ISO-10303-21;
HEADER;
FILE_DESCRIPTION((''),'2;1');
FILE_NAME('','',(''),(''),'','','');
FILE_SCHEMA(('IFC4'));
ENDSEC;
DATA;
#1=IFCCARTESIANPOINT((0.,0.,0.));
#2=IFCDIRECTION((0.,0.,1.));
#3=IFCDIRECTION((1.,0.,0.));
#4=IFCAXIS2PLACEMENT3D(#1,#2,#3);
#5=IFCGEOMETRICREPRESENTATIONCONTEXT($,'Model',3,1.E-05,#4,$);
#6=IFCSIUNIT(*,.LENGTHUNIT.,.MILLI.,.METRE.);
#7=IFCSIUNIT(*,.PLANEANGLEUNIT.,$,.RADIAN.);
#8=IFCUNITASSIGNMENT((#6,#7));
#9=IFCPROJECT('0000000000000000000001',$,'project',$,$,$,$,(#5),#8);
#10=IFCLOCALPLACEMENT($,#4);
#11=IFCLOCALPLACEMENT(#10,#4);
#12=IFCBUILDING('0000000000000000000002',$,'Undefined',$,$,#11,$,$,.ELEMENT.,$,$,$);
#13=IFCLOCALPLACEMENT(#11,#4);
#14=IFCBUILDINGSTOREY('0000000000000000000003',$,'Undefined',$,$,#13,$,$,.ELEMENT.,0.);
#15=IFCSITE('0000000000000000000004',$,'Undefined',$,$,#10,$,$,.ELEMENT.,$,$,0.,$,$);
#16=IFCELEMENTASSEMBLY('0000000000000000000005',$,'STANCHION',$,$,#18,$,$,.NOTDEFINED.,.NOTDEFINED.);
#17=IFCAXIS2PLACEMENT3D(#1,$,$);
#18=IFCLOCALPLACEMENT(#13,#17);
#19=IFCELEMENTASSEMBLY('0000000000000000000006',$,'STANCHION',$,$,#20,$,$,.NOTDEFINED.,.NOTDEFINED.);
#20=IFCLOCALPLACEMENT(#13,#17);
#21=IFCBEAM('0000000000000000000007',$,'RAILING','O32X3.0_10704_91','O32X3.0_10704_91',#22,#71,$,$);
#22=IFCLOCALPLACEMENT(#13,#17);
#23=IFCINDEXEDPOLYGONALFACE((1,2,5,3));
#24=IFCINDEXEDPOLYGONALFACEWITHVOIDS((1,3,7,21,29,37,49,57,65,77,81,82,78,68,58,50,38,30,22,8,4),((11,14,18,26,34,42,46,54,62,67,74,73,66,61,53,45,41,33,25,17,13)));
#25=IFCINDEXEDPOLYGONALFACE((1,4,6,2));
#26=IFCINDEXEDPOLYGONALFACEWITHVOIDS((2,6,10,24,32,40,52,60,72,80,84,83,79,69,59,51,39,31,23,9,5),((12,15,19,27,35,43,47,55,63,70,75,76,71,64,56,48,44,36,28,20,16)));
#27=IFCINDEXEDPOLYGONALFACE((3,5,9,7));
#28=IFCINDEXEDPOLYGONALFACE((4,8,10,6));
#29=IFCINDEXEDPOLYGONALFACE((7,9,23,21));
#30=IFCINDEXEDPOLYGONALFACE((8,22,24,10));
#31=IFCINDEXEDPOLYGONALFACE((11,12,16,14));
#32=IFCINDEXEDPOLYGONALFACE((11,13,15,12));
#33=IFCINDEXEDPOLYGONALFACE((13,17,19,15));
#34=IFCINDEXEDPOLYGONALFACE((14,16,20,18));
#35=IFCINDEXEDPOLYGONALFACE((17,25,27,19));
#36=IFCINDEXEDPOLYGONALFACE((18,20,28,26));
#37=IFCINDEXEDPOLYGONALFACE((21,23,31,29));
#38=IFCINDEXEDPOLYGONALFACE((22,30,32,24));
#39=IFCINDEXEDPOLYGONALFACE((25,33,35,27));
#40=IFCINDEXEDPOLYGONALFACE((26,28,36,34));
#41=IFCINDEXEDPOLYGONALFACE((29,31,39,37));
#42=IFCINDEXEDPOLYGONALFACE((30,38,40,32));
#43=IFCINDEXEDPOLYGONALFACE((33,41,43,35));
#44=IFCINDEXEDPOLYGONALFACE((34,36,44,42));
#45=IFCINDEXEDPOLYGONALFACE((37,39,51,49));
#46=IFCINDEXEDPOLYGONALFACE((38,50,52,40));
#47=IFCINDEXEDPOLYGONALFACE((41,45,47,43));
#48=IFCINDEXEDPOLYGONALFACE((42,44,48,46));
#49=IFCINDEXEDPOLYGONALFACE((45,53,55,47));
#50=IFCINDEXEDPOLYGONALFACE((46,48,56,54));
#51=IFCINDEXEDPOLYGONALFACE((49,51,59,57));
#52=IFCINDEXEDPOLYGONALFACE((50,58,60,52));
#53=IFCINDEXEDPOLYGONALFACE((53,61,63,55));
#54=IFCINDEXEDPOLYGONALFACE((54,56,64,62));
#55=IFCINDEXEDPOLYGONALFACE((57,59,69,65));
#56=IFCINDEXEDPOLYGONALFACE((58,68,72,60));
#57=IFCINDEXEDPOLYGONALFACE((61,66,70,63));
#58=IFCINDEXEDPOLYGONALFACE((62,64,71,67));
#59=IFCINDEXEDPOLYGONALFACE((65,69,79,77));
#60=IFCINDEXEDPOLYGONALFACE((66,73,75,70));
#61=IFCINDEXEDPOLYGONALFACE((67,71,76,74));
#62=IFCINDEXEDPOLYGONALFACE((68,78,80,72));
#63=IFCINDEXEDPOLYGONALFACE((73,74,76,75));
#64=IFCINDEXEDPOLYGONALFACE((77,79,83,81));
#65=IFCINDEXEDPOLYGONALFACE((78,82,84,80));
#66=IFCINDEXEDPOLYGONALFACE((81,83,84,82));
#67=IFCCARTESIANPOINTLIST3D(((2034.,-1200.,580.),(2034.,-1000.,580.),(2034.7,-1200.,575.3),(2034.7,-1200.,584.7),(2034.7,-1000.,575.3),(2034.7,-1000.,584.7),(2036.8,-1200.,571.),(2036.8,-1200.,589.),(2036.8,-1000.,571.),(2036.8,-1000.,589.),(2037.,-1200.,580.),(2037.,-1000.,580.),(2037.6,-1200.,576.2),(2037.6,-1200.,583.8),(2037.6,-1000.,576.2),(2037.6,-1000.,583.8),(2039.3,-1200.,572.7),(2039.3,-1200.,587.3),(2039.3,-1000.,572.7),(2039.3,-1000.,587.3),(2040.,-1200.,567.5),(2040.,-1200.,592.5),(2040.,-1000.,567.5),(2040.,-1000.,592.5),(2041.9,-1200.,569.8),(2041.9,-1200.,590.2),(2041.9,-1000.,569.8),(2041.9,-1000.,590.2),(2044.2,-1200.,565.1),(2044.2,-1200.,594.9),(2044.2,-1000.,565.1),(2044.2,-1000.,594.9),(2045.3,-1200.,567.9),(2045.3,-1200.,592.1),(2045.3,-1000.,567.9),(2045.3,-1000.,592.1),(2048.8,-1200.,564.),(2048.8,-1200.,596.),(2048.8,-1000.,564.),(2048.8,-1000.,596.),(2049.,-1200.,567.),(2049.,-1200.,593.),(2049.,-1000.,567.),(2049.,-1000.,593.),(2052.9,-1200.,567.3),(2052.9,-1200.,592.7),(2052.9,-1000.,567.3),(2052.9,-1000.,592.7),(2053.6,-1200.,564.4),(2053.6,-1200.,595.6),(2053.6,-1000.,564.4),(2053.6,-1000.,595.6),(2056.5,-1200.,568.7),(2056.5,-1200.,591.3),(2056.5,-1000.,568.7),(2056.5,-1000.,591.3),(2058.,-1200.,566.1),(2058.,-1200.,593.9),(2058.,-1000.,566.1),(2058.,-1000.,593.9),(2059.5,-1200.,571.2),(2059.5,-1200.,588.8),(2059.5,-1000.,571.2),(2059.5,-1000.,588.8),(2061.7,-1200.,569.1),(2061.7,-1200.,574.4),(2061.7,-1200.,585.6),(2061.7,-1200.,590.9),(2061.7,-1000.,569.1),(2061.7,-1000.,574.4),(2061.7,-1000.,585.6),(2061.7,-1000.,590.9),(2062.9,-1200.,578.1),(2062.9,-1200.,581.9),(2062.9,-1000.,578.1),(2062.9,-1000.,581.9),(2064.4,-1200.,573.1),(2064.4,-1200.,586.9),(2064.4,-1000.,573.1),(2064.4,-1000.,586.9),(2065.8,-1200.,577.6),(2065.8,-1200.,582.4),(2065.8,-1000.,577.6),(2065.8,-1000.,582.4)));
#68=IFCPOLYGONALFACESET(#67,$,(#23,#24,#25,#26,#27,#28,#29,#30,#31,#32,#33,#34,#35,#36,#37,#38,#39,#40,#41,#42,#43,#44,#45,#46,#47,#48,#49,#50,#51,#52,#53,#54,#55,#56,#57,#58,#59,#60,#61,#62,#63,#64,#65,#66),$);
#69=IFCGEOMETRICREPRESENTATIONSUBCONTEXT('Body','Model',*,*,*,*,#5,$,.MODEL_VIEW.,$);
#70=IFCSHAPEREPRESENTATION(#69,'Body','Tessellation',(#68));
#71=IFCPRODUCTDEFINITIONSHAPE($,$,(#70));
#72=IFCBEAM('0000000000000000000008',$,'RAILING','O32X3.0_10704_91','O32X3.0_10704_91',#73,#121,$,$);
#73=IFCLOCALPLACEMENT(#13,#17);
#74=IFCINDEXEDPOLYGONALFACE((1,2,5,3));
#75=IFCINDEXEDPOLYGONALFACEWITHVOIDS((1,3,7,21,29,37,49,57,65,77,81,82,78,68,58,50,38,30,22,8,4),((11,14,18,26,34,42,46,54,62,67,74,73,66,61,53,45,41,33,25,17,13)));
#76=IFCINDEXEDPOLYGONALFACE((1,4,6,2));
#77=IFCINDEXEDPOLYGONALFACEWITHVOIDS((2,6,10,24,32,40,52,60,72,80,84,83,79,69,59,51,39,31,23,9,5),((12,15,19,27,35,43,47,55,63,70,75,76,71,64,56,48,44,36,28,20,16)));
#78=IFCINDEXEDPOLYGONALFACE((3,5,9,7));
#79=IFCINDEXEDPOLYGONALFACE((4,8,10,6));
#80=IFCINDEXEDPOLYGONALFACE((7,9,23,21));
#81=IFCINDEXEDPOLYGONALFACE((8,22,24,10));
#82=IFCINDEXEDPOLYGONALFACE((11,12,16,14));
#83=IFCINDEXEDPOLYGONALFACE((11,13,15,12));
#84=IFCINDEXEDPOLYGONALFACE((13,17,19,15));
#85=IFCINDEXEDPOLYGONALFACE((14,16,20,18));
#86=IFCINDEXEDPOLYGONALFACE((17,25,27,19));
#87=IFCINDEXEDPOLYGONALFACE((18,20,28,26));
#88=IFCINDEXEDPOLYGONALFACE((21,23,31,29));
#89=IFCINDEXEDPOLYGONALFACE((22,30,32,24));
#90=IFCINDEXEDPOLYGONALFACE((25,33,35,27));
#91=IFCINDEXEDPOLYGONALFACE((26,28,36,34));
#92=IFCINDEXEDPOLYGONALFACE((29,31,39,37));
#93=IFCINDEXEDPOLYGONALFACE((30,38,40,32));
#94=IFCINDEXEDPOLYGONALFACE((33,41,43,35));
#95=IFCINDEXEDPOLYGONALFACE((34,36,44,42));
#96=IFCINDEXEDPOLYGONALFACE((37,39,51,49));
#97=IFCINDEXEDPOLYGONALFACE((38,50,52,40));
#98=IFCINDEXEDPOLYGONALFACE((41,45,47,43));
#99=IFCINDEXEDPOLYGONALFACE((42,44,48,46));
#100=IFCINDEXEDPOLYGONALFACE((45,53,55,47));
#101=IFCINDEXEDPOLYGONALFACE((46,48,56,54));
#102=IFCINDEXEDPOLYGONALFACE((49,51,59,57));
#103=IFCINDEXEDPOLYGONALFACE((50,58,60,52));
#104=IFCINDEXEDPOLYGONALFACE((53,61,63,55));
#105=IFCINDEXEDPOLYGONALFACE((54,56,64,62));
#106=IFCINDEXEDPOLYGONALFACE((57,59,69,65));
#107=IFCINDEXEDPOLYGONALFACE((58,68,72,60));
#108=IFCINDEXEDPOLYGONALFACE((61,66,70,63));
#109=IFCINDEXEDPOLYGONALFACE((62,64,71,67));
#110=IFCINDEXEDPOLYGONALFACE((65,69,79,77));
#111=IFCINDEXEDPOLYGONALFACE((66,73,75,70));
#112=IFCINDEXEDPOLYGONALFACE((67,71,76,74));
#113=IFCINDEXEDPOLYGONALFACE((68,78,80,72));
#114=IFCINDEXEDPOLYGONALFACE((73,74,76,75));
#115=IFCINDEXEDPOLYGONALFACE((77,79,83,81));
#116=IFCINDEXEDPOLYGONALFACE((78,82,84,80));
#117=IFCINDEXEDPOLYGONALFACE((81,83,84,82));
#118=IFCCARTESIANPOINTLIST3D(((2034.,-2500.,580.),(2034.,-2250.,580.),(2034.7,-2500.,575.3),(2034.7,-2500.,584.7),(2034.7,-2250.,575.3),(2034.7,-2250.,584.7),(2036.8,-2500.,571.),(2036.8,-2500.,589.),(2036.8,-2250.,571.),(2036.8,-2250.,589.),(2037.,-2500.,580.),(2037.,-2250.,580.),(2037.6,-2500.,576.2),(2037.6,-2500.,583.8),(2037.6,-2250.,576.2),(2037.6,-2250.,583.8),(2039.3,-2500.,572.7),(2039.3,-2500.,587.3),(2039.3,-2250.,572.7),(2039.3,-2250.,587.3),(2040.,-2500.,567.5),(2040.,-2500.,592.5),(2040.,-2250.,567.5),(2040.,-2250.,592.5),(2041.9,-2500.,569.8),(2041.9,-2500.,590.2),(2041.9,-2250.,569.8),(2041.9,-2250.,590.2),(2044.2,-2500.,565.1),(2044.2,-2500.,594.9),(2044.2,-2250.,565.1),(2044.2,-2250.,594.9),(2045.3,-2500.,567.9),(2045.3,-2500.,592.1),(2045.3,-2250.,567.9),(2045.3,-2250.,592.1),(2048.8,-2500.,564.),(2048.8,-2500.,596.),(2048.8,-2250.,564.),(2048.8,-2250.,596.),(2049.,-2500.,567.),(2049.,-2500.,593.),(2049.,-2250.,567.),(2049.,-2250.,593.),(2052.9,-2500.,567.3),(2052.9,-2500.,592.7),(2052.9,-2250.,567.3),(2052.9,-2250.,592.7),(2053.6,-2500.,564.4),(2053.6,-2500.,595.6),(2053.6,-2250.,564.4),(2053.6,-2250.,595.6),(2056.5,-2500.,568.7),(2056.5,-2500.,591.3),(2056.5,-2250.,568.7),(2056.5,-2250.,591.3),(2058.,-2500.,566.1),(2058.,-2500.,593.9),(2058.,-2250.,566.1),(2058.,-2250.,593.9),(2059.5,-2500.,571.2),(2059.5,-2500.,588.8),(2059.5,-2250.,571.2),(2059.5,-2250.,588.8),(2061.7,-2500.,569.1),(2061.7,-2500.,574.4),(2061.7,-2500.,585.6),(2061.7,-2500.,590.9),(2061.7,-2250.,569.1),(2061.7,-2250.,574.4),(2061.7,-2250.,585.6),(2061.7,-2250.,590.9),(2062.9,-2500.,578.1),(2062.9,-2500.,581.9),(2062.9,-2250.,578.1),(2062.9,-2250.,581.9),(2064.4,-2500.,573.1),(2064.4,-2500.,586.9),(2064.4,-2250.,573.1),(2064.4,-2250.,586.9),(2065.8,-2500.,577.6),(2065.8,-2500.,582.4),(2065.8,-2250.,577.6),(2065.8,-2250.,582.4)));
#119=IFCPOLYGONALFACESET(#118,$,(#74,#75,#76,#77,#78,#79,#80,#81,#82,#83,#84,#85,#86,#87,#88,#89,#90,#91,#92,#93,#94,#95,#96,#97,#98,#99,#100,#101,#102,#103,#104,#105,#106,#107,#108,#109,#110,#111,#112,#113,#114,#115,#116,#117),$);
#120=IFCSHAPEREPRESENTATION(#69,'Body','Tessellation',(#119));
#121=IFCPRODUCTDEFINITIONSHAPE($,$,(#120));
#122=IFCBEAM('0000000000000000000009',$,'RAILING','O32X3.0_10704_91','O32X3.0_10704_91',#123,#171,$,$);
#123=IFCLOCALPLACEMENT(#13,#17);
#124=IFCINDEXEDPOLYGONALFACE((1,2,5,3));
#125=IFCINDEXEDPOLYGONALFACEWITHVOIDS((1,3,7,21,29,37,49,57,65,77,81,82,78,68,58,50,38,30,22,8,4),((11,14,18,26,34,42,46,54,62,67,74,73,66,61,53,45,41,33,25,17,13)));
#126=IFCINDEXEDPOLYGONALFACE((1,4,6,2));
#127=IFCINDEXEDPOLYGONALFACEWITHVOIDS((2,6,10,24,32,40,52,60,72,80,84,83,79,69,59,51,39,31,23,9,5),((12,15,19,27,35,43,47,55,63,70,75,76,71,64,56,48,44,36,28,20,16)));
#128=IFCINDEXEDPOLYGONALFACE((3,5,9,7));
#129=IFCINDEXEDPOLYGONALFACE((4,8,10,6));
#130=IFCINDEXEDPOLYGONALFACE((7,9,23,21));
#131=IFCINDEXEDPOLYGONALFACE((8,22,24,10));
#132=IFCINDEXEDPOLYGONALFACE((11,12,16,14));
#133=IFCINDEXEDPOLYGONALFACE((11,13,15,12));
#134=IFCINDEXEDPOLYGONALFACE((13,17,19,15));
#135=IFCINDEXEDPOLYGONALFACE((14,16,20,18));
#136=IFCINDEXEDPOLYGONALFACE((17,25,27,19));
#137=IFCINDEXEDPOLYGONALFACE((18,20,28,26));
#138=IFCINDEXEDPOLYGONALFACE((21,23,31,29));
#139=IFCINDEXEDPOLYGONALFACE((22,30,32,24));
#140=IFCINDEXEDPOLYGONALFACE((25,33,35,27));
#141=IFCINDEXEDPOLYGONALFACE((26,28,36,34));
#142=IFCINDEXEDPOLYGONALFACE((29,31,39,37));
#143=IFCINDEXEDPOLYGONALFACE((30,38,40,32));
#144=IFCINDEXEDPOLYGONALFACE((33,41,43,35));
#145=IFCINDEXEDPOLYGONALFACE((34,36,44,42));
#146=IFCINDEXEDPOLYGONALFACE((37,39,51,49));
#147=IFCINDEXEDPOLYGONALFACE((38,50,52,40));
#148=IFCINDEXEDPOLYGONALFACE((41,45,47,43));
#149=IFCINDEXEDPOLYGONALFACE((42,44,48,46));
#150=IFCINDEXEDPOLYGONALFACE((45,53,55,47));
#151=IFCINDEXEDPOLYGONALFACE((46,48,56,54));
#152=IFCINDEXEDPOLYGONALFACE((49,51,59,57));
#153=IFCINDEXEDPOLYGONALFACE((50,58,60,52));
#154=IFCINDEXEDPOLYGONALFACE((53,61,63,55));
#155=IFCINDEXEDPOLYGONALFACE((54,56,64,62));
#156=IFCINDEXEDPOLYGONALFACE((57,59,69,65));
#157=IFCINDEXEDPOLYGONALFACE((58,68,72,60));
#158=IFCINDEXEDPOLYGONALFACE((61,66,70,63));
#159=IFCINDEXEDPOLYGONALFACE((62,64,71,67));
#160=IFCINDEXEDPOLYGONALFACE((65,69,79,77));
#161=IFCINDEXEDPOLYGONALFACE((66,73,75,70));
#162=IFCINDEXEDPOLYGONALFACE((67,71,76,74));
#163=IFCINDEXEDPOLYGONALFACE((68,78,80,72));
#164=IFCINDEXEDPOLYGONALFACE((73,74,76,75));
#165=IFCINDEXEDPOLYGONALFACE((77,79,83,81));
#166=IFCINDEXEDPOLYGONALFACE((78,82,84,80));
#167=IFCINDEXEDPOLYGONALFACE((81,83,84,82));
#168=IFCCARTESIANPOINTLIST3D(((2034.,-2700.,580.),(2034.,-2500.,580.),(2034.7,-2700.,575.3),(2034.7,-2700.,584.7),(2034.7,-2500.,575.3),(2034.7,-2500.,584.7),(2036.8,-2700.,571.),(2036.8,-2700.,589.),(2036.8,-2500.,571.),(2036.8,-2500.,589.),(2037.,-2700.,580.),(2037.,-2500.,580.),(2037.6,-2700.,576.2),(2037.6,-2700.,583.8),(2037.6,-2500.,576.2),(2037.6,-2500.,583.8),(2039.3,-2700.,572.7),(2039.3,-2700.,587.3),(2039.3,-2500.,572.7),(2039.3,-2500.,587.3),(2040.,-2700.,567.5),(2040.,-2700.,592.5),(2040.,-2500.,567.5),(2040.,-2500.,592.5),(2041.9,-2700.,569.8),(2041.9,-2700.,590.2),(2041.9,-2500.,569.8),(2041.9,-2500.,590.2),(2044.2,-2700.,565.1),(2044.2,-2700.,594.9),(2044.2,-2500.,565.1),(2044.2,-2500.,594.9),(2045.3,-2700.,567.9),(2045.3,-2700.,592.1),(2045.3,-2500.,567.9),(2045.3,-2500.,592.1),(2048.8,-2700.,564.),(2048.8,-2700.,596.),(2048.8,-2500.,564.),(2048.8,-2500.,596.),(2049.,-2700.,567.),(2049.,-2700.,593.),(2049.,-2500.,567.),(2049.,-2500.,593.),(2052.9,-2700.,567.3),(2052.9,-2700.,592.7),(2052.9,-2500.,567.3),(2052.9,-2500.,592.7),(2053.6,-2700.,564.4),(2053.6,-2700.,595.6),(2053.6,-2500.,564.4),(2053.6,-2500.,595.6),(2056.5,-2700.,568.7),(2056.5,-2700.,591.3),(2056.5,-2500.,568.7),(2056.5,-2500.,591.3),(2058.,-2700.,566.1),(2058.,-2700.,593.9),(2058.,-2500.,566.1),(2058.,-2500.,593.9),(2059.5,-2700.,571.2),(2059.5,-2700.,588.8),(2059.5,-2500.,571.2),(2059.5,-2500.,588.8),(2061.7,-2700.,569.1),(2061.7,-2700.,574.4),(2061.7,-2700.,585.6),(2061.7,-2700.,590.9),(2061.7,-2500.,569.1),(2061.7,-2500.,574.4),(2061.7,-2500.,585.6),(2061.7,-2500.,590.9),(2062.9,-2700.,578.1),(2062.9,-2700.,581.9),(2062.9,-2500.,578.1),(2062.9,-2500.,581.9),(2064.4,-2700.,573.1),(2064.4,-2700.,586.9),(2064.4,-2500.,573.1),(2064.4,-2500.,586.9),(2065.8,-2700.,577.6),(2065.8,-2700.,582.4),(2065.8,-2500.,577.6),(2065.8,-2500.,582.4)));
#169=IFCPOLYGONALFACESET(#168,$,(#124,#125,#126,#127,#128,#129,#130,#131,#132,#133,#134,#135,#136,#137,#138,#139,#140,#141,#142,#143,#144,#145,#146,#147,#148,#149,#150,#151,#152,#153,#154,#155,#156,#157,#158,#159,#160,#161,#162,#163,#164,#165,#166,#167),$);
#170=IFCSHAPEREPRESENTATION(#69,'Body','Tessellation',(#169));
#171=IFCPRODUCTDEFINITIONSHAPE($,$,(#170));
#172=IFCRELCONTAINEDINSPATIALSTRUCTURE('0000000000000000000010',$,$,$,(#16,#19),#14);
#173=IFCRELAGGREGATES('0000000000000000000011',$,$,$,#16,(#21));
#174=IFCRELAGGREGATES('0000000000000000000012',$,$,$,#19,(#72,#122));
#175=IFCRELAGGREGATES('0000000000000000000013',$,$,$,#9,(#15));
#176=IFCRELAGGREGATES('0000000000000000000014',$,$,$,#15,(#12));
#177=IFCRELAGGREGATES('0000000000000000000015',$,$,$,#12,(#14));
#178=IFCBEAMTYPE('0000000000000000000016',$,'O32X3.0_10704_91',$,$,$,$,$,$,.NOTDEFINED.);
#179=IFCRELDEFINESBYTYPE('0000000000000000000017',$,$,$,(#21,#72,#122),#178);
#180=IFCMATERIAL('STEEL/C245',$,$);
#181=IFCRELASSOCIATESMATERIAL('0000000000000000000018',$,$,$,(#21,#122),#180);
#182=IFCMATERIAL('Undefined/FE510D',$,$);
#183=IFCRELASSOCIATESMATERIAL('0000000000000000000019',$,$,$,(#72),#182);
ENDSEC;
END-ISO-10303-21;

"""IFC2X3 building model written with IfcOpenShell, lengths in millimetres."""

from ifc_helpers import new_model, si_unit, frame, origin_with_axes, origin_2d_with_axis, place, context, subcontext, project, spatial, hollow_circle, extrude, material, type_object, element, aggregate, save


model = new_model("IFC2X3")

# Units and contexts
model_context = context("Model", 3, precision=1e-05, world=origin_with_axes())
body_context = subcontext(model_context, "Body", "Model", "MODEL_VIEW")
ifc_project = project(units=[si_unit("LENGTHUNIT", "METRE", prefix="MILLI"), si_unit("PLANEANGLEUNIT", "RADIAN")], contexts=[model_context])

# Site, building, storey
site_placement = place(None, origin_with_axes())
site = spatial("IfcSite", under=ifc_project, at=site_placement, Name="Undefined", CompositionType="ELEMENT", RefElevation=0.0)
building_placement = place(site_placement, origin_with_axes())
building = spatial("IfcBuilding", under=site, at=building_placement, Name="Undefined", CompositionType="ELEMENT")
storey_placement = place(building_placement, origin_with_axes())
storey = spatial("IfcBuildingStorey", under=building, at=storey_placement, Name="Undefined", CompositionType="ELEMENT", Elevation=0.0)

# Element assembly
assembly_1_placement = place(storey_placement, origin_with_axes())
assembly_1 = element("IfcElementAssembly", 1, at=assembly_1_placement, inside=storey, Name="STANCHION", AssemblyPlace="NOTDEFINED", PredefinedType="NOTDEFINED")
ifc_material_1 = material(Name="STEEL/C245")

# Shared definitions
ifc_material_2 = material(Name="Undefined/FE510D")

# Element assembly
assembly_2_placement = place(storey_placement, origin_with_axes())
assembly_2 = element("IfcElementAssembly", 2, at=assembly_2_placement, inside=storey, Name="STANCHION", AssemblyPlace="NOTDEFINED", PredefinedType="NOTDEFINED")

# Beams
beam_type_1 = type_object("IfcBeamType", Name="O32X3.0_10704_91", PredefinedType="NOTDEFINED")
beam_1_placement = place(assembly_1_placement, frame((2050.0, -1200.0, 580.0), z_axis=(0.0, 0.0, -1.0), x_axis=(0.0, 1.0, 0.0)))
beam_1 = element("IfcBeam", 3, at=beam_1_placement, type_object=beam_type_1, material=ifc_material_1, Name="RAILING", Description="O32X3.0_10704_91", ObjectType="O32X3.0_10704_91", context=body_context, shape_type="SweptSolid", body=[
    extrude(hollow_circle(Radius=16.0, WallThickness=3.0, at=origin_2d_with_axis()), frame((200.0, 0.0, 0.0), z_axis=(-1.0, 0.0, 0.0), x_axis=(0.0, -1.0, 0.0)), (0.0, 0.0, 1.0), 200.0),
])
aggregate(assembly_1, [beam_1])
beam_2_placement = place(assembly_2_placement, frame((2050.0, -2500.0, 580.0), z_axis=(0.0, 0.0, -1.0), x_axis=(0.0, 1.0, 0.0)))
beam_2 = element("IfcBeam", 4, at=beam_2_placement, type_object=beam_type_1, material=ifc_material_2, Name="RAILING", Description="O32X3.0_10704_91", ObjectType="O32X3.0_10704_91", context=body_context, shape_type="SweptSolid", body=[
    extrude(hollow_circle(Radius=16.0, WallThickness=3.0, at=origin_2d_with_axis()), frame((250.0, 0.0, 0.0), z_axis=(-1.0, 0.0, 0.0), x_axis=(0.0, -1.0, 0.0)), (0.0, 0.0, 1.0), 250.0),
])
beam_3_placement = place(assembly_2_placement, frame((2050.0, -2700.0, 580.0), z_axis=(0.0, 0.0, -1.0), x_axis=(0.0, 1.0, 0.0)))
beam_3 = element("IfcBeam", 5, at=beam_3_placement, type_object=beam_type_1, material=ifc_material_1, Name="RAILING", Description="O32X3.0_10704_91", ObjectType="O32X3.0_10704_91", context=body_context, shape_type="SweptSolid", body=[
    extrude(hollow_circle(Radius=16.0, WallThickness=3.0, at=origin_2d_with_axis()), frame((200.0, 0.0, 0.0), z_axis=(-1.0, 0.0, 0.0), x_axis=(0.0, -1.0, 0.0)), (0.0, 0.0, 1.0), 200.0),
])
aggregate(assembly_2, [beam_2, beam_3])

save(model, "model.ifc")
